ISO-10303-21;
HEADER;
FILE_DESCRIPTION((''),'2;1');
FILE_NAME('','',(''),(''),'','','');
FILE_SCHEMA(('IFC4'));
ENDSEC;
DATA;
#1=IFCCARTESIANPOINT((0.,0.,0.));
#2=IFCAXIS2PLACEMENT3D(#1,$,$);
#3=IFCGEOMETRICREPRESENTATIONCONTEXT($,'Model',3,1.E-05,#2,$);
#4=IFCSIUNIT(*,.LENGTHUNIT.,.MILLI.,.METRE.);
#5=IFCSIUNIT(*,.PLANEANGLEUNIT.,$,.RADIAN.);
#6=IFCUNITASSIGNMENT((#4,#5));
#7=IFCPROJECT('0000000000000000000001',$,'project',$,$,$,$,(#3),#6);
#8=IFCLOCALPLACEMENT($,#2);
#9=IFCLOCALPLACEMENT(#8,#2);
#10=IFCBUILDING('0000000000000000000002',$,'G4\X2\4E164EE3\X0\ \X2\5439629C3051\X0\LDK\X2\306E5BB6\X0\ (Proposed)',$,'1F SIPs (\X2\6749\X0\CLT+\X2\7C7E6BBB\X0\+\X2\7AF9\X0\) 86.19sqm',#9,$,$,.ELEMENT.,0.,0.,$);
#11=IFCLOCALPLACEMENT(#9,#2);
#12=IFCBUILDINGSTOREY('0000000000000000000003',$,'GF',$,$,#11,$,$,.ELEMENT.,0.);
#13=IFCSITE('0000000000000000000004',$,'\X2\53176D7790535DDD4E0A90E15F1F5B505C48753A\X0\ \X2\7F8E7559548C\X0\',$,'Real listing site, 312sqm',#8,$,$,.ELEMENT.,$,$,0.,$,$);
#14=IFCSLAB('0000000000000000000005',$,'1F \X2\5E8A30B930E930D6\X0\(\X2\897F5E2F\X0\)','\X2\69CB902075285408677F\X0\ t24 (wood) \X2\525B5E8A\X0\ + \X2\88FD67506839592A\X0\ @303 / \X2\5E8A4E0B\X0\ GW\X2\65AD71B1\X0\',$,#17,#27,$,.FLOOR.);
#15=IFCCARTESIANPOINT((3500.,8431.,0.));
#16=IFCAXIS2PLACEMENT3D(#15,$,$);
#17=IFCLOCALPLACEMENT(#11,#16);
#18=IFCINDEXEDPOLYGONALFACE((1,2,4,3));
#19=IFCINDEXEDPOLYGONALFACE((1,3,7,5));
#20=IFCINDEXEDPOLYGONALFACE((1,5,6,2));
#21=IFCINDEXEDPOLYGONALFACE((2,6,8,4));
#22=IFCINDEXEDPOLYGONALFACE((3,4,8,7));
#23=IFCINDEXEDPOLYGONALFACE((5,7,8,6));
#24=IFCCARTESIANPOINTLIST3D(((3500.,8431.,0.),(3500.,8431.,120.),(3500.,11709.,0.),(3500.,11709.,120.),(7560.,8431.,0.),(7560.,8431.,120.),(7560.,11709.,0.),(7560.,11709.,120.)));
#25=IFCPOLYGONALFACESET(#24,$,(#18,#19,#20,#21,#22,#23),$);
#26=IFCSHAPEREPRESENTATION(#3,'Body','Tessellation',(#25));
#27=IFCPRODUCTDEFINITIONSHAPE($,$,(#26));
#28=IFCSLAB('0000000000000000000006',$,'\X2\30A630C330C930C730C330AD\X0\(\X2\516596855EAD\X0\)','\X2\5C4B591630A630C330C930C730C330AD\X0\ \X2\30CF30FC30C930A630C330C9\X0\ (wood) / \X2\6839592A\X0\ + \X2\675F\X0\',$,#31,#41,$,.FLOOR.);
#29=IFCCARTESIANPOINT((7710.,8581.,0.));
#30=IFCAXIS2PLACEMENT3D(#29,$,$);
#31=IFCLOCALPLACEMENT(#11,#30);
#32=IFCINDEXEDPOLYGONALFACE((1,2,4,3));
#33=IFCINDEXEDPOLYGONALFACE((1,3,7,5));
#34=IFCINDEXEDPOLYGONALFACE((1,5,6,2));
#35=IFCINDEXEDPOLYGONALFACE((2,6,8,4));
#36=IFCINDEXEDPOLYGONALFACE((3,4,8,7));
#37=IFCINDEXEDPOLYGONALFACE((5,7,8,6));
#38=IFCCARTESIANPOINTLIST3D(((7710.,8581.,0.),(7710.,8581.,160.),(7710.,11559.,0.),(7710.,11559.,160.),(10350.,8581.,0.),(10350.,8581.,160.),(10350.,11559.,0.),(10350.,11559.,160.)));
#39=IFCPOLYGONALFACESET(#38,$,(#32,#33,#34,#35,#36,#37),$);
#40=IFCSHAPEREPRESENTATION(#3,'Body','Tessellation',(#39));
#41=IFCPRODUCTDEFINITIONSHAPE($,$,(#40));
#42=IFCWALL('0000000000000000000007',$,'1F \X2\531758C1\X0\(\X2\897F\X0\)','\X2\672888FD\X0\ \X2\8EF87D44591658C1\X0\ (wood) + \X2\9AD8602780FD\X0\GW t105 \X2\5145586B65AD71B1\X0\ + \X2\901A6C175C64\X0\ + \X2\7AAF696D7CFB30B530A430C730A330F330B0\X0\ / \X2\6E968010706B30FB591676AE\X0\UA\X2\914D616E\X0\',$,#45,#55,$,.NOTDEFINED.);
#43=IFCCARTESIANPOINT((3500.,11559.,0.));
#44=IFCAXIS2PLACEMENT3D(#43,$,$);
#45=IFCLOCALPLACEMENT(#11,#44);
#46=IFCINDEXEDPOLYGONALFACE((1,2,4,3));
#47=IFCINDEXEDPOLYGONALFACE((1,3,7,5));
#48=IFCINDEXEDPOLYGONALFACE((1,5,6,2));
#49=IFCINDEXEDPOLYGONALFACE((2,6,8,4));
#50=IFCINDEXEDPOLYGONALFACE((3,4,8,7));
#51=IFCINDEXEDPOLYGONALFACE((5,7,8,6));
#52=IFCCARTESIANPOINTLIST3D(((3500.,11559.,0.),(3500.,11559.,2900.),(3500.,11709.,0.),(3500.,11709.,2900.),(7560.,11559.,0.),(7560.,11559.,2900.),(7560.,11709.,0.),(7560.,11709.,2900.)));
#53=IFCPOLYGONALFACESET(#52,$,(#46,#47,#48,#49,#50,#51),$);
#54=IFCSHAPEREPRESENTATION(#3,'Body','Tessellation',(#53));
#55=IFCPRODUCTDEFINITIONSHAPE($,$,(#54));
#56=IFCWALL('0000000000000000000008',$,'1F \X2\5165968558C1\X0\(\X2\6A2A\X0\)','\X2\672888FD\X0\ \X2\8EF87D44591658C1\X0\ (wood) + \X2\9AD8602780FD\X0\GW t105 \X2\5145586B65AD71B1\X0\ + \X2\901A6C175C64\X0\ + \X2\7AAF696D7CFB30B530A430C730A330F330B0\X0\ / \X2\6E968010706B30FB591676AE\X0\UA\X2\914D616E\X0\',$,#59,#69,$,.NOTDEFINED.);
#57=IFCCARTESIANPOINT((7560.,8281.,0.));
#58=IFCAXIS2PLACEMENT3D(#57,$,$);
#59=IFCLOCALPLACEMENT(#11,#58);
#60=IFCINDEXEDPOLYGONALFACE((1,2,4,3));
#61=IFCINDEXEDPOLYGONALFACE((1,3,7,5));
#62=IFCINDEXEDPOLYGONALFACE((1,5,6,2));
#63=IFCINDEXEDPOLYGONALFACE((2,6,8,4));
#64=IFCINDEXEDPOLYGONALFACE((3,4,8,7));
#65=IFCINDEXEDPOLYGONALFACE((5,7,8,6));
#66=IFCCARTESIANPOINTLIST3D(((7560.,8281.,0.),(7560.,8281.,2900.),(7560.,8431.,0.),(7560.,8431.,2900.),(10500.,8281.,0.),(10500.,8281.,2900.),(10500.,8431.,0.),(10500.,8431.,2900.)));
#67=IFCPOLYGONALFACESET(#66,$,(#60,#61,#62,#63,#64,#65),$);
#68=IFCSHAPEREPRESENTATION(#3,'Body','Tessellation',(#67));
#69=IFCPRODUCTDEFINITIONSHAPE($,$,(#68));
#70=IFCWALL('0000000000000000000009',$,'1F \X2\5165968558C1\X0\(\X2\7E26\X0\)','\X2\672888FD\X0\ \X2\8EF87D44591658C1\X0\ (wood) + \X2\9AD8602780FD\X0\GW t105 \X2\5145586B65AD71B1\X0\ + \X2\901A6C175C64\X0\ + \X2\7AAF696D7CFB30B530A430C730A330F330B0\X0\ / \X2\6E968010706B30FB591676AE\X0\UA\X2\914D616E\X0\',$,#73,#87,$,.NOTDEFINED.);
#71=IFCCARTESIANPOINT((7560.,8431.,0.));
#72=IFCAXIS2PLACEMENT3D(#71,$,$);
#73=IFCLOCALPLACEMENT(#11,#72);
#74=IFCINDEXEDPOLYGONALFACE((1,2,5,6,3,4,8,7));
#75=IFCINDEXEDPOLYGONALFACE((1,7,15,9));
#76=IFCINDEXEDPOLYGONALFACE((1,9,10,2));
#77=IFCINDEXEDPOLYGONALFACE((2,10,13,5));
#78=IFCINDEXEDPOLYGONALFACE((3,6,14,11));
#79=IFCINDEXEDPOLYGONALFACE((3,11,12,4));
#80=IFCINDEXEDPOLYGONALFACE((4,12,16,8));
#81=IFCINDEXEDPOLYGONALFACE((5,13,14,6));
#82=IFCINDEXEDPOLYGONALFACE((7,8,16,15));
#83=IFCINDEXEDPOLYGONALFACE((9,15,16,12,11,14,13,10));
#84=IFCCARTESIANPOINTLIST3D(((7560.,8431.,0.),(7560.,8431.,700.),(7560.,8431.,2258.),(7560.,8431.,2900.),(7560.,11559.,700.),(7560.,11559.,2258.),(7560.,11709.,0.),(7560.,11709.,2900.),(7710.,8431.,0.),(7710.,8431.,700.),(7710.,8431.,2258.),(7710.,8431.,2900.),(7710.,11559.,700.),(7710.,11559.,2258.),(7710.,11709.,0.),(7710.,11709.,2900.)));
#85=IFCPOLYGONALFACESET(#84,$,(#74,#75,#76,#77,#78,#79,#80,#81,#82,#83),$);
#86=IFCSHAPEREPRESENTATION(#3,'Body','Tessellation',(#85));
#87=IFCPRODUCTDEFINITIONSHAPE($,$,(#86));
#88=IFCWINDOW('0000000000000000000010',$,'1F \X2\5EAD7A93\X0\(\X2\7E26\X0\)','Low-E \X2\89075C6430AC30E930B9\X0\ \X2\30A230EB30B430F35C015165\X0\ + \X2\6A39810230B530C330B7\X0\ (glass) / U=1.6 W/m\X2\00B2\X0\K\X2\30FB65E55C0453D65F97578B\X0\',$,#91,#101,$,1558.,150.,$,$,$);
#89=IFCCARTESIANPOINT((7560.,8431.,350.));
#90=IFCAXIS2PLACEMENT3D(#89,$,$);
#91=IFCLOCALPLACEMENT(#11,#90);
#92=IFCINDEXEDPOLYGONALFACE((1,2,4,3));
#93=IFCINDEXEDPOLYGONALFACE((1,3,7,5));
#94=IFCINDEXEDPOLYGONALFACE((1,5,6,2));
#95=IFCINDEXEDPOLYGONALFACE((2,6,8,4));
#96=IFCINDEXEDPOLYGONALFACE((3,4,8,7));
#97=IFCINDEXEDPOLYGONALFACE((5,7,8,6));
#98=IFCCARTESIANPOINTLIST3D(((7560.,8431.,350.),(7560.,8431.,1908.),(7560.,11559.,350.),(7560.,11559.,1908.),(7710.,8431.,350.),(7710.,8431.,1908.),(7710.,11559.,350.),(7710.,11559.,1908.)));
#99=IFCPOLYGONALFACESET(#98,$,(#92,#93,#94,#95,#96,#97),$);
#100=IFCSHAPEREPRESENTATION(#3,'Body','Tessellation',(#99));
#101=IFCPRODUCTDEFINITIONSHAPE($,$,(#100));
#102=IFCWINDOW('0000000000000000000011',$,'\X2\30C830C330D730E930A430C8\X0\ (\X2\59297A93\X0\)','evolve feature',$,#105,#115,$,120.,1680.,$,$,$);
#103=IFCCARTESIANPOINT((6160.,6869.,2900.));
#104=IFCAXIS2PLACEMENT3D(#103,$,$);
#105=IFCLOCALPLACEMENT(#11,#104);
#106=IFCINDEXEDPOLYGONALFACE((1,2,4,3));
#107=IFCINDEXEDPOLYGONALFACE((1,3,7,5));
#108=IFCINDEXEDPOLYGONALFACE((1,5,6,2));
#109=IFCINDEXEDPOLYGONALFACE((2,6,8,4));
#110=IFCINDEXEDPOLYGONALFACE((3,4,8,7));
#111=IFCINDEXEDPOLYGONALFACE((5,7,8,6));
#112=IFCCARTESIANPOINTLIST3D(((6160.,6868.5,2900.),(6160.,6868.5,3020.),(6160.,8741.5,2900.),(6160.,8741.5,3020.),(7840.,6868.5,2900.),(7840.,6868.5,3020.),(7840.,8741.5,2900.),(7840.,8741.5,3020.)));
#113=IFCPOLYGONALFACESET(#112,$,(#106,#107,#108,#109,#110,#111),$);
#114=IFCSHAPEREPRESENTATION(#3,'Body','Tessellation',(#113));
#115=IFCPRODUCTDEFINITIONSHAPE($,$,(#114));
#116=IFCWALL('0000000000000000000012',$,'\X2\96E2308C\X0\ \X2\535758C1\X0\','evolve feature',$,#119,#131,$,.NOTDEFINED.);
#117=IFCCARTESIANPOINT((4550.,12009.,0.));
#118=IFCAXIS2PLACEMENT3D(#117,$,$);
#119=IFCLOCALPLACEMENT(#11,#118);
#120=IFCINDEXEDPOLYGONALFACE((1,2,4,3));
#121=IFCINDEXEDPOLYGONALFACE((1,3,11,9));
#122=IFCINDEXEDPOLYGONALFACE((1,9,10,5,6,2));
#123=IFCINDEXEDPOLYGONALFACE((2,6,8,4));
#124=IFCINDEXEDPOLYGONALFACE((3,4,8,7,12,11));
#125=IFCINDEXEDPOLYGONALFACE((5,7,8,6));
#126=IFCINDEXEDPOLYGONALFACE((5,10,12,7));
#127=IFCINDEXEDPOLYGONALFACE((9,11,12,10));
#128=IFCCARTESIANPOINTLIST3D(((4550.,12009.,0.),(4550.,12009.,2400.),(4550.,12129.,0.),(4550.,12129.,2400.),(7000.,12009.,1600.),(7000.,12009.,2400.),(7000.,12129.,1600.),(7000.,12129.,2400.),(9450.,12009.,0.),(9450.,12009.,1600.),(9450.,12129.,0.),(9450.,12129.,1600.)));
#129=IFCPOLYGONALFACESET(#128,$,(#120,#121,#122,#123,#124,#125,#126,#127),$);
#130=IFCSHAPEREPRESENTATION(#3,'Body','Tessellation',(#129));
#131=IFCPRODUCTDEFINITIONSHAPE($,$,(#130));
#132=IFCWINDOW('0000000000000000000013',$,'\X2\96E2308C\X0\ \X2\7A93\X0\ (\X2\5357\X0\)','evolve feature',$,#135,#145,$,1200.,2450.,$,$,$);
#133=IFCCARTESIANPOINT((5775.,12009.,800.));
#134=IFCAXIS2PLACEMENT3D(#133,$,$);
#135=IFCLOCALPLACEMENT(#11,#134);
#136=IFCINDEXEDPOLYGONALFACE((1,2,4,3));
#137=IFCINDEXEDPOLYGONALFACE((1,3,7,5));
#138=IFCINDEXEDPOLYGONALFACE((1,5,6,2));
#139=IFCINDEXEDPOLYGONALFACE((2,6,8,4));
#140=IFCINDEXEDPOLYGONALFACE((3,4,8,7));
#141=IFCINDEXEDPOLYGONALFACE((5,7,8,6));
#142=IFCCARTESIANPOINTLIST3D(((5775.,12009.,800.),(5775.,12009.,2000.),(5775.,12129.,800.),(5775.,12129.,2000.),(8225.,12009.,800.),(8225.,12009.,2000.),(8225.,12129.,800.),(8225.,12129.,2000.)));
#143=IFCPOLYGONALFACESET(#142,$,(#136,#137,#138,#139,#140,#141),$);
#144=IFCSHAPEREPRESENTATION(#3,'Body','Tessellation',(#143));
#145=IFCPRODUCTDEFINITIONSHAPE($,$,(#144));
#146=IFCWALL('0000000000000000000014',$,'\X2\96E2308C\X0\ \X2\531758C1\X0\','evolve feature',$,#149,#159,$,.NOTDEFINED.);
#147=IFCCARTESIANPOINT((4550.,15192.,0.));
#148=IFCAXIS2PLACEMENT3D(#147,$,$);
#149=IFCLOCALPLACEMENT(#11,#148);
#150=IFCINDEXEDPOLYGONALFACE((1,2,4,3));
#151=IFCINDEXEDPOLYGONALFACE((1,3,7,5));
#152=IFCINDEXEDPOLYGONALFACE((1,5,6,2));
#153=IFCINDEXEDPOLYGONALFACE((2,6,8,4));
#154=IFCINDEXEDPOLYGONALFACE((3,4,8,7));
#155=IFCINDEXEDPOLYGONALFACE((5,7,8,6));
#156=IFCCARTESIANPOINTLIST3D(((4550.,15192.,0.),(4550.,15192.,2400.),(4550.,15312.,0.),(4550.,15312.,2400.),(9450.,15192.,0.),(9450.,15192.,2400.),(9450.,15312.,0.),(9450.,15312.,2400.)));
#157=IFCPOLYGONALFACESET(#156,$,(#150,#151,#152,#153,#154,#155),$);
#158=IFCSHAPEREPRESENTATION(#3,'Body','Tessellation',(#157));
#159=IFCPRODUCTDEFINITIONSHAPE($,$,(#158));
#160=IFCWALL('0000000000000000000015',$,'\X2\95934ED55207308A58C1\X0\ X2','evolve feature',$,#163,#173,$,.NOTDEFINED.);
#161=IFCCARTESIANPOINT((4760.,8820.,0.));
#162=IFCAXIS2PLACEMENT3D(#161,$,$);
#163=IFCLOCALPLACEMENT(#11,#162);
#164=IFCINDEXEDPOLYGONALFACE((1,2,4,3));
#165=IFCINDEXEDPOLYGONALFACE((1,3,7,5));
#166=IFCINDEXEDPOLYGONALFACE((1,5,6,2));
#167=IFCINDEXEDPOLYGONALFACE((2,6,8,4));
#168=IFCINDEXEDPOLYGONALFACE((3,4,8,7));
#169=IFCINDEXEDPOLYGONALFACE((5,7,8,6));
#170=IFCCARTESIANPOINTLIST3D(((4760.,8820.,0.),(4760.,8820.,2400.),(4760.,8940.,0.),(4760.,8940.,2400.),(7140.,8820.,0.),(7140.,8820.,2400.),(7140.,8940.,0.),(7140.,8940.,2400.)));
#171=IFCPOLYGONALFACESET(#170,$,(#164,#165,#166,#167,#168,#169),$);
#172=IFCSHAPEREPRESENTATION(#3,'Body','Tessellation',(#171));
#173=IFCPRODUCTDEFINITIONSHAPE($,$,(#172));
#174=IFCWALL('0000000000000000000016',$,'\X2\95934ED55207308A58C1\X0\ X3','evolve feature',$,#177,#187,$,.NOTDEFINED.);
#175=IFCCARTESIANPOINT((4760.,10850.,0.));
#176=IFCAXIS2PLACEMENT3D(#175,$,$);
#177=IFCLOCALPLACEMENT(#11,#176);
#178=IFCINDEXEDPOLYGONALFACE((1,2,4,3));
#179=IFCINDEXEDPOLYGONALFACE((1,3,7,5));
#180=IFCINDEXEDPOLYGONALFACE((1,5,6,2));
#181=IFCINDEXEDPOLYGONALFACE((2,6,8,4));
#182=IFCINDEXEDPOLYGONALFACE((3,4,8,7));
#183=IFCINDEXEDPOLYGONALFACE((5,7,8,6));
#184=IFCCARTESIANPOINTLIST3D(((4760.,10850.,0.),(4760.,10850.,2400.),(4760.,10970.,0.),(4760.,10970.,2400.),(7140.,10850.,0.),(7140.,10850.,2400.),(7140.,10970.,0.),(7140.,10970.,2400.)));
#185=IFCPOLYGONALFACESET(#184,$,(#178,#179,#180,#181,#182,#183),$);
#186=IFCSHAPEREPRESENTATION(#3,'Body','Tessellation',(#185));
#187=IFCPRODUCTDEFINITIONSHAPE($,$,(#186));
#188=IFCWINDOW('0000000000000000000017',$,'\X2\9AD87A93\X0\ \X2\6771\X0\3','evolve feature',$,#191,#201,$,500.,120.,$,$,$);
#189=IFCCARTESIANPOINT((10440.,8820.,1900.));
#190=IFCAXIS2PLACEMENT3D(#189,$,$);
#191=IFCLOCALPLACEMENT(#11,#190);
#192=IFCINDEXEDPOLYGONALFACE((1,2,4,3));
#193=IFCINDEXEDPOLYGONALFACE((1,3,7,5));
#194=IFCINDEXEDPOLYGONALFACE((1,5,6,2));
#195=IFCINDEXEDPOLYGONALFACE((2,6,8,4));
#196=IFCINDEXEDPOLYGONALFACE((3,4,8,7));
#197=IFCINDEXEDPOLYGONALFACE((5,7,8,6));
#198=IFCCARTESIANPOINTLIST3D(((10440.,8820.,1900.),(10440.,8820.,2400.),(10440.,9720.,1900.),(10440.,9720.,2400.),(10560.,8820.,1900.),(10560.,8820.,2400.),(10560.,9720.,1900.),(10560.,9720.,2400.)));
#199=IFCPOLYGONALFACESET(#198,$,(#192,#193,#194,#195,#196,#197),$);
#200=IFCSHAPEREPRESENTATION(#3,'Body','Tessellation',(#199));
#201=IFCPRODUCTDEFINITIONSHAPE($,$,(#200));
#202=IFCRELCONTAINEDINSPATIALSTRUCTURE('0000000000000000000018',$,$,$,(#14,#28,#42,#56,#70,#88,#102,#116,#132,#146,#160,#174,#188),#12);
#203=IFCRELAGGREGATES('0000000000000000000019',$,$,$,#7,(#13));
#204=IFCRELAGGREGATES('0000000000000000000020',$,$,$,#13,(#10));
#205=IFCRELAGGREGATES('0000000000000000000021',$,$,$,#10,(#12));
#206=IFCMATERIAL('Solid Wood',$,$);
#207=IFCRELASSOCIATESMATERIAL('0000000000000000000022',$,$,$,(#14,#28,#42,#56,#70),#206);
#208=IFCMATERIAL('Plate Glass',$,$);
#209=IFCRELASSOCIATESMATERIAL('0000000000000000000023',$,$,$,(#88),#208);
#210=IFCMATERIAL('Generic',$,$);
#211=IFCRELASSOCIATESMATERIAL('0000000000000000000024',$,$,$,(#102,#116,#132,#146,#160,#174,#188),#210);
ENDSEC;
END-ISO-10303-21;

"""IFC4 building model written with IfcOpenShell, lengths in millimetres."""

from ifc_helpers import new_model, si_unit, frame, frame_2d, origin, place, context, project, spatial, rectangle, extrude, material, element, fill, save


model = new_model("IFC4")

# Units and contexts
model_context = context("Model", 3, precision=1e-05, world=origin())
ifc_project = project(units=[si_unit("LENGTHUNIT", "METRE", prefix="MILLI"), si_unit("PLANEANGLEUNIT", "RADIAN")], contexts=[model_context])

# Site, building, storey
site_placement = place(None, origin())
site = spatial("IfcSite", under=ifc_project, at=site_placement, Name="北海道川上郡弟子屈町 美留和", ObjectType="Real listing site, 312sqm", CompositionType="ELEMENT", RefElevation=0.0)
building_placement = place(site_placement, origin())
building = spatial("IfcBuilding", under=site, at=building_placement, Name="G4世代 吹抜けLDKの家 (Proposed)", ObjectType="1F SIPs (杉CLT+籾殻+竹) 86.19sqm", CompositionType="ELEMENT", ElevationOfRefHeight=0.0, ElevationOfTerrain=0.0)
storey_placement = place(building_placement, origin())
storey = spatial("IfcBuildingStorey", under=building, at=storey_placement, Name="GF", CompositionType="ELEMENT", Elevation=0.0)

# Slabs
ifc_material_1 = material(Name="Solid Wood")
slab_1_placement = place(storey_placement, frame((3500.0, 8431.0, 0.0)))
element("IfcSlab", 1, at=slab_1_placement, inside=storey, material=ifc_material_1, Name="1F 床スラブ(西帯)", Description="構造用合板 t24 (wood) 剛床 + 製材根太 @303 / 床下 GW断熱", PredefinedType="FLOOR", context=model_context, shape_type="SweptSolid", body=[
    extrude(rectangle(XDim=4060.0, YDim=3278.0, at=frame_2d((2030.0, 1639.0))), frame((3500.0, 8431.0, 0.0)), (0.0, 0.0, 1.0), 120.0),
])
slab_2_placement = place(storey_placement, frame((7710.0, 8581.0, 0.0)))
element("IfcSlab", 2, at=slab_2_placement, inside=storey, material=ifc_material_1, Name="ウッドデッキ(入隅庭)", Description="屋外ウッドデッキ ハードウッド (wood) / 根太 + 束", PredefinedType="FLOOR", context=model_context, shape_type="SweptSolid", body=[
    extrude(rectangle(XDim=2640.0, YDim=2978.0, at=frame_2d((1320.0, 1489.0))), frame((7710.0, 8581.0, 0.0)), (0.0, 0.0, 1.0), 160.0),
])
ifc_material_2 = material(Name="Generic")

# Walls
wall_1_placement = place(storey_placement, frame((3500.0, 11559.0, 0.0)))
element("IfcWall", 3, at=wall_1_placement, inside=storey, material=ifc_material_1, Name="1F 北壁(西)", Description="木製 軸組外壁 (wood) + 高性能GW t105 充填断熱 + 通気層 + 窯業系サイディング / 準耐火・外皮UA配慮", PredefinedType="NOTDEFINED", context=model_context, shape_type="SweptSolid", body=[
    extrude(rectangle(XDim=4060.0, YDim=150.0, at=frame_2d((2030.0, 75.0))), frame((3500.0, 11559.0, 0.0)), (0.0, 0.0, 1.0), 2900.0),
])
wall_2_placement = place(storey_placement, frame((7560.0, 8281.0, 0.0)))
element("IfcWall", 4, at=wall_2_placement, inside=storey, material=ifc_material_1, Name="1F 入隅壁(横)", Description="木製 軸組外壁 (wood) + 高性能GW t105 充填断熱 + 通気層 + 窯業系サイディング / 準耐火・外皮UA配慮", PredefinedType="NOTDEFINED", context=model_context, shape_type="SweptSolid", body=[
    extrude(rectangle(XDim=2940.0, YDim=150.0, at=frame_2d((1470.0, 75.0))), frame((7560.0, 8281.0, 0.0)), (0.0, 0.0, 1.0), 2900.0),
])

# Wall, opening, window
wall_3_placement = place(storey_placement, frame((7560.0, 8431.0, 0.0)))
wall_3 = element("IfcWall", 5, at=wall_3_placement, inside=storey, material=ifc_material_1, Name="1F 入隅壁(縦)", Description="木製 軸組外壁 (wood) + 高性能GW t105 充填断熱 + 通気層 + 窯業系サイディング / 準耐火・外皮UA配慮", PredefinedType="NOTDEFINED", context=model_context, shape_type="SweptSolid", body=[
    extrude(rectangle(XDim=150.0, YDim=3278.0, at=frame_2d((75.0, 1639.0))), frame((7560.0, 8431.0, 0.0)), (0.0, 0.0, 1.0), 2900.0),
])
opening_1_placement = place(storey_placement, frame((7560.0, 8431.0, 350.0)))
opening_1 = element("IfcOpeningElement", 6, at=opening_1_placement, cuts=wall_3, PredefinedType="NOTDEFINED", context=model_context, shape_type="SweptSolid", body=[
    extrude(rectangle(XDim=150.0, YDim=3128.0, at=frame_2d((75.0, 1564.0))), frame((7560.0, 8431.0, 350.0)), (0.0, 0.0, 1.0), 1558.0),
])
ifc_material_3 = material(Name="Plate Glass")
window_1_placement = place(storey_placement, frame((7560.0, 8431.0, 350.0)))
window_1 = element("IfcWindow", 7, at=window_1_placement, inside=storey, material=ifc_material_3, Name="1F 庭窓(縦)", Description="Low-E 複層ガラス アルゴン封入 + 樹脂サッシ (glass) / U=1.6 W/m²K・日射取得型", OverallHeight=1558.0, OverallWidth=150.0, context=model_context, shape_type="SweptSolid", body=[
    extrude(rectangle(XDim=150.0, YDim=3128.0, at=frame_2d((75.0, 1564.0))), frame((7560.0, 8431.0, 350.0)), (0.0, 0.0, 1.0), 1558.0),
])
fill(opening_1, window_1)

# Window
window_2_placement = place(storey_placement, frame((6160.0, 6869.0, 2900.0)))
element("IfcWindow", 8, at=window_2_placement, inside=storey, material=ifc_material_2, Name="トップライト (天窓)", Description="evolve feature", OverallHeight=120.0, OverallWidth=1680.0, context=model_context, shape_type="SweptSolid", body=[
    extrude(rectangle(XDim=1680.0, YDim=1873.0, at=frame_2d((840.0, 936.0))), frame((6160.0, 6869.0, 2900.0)), (0.0, 0.0, 1.0), 120.0),
])

# Wall, opening, window
wall_4_placement = place(storey_placement, frame((4550.0, 12009.0, 0.0)))
wall_4 = element("IfcWall", 9, at=wall_4_placement, inside=storey, material=ifc_material_2, Name="離れ 南壁", Description="evolve feature", PredefinedType="NOTDEFINED", context=model_context, shape_type="SweptSolid", body=[
    extrude(rectangle(XDim=4900.0, YDim=120.0, at=frame_2d((2450.0, 60.0))), frame((4550.0, 12009.0, 0.0)), (0.0, 0.0, 1.0), 2400.0),
])
opening_2_placement = place(storey_placement, frame((5775.0, 12009.0, 800.0)))
opening_2 = element("IfcOpeningElement", 10, at=opening_2_placement, cuts=wall_4, PredefinedType="NOTDEFINED", context=model_context, shape_type="SweptSolid", body=[
    extrude(rectangle(XDim=2450.0, YDim=120.0, at=frame_2d((1225.0, 60.0))), frame((5775.0, 12009.0, 800.0)), (0.0, 0.0, 1.0), 1200.0),
])
window_3_placement = place(storey_placement, frame((5775.0, 12009.0, 800.0)))
window_3 = element("IfcWindow", 11, at=window_3_placement, inside=storey, material=ifc_material_2, Name="離れ 窓 (南)", Description="evolve feature", OverallHeight=1200.0, OverallWidth=2450.0, context=model_context, shape_type="SweptSolid", body=[
    extrude(rectangle(XDim=2450.0, YDim=120.0, at=frame_2d((1225.0, 60.0))), frame((5775.0, 12009.0, 800.0)), (0.0, 0.0, 1.0), 1200.0),
])
fill(opening_2, window_3)

# Walls
wall_5_placement = place(storey_placement, frame((4550.0, 15192.0, 0.0)))
element("IfcWall", 12, at=wall_5_placement, inside=storey, material=ifc_material_2, Name="離れ 北壁", Description="evolve feature", PredefinedType="NOTDEFINED", context=model_context, shape_type="SweptSolid", body=[
    extrude(rectangle(XDim=4900.0, YDim=120.0, at=frame_2d((2450.0, 60.0))), frame((4550.0, 15192.0, 0.0)), (0.0, 0.0, 1.0), 2400.0),
])
wall_6_placement = place(storey_placement, frame((4760.0, 8820.0, 0.0)))
element("IfcWall", 13, at=wall_6_placement, inside=storey, material=ifc_material_2, Name="間仕切り壁 X2", Description="evolve feature", PredefinedType="NOTDEFINED", context=model_context, shape_type="SweptSolid", body=[
    extrude(rectangle(XDim=2380.0, YDim=120.0, at=frame_2d((1190.0, 60.0))), frame((4760.0, 8820.0, 0.0)), (0.0, 0.0, 1.0), 2400.0),
])
wall_7_placement = place(storey_placement, frame((4760.0, 10850.0, 0.0)))
element("IfcWall", 14, at=wall_7_placement, inside=storey, material=ifc_material_2, Name="間仕切り壁 X3", Description="evolve feature", PredefinedType="NOTDEFINED", context=model_context, shape_type="SweptSolid", body=[
    extrude(rectangle(XDim=2380.0, YDim=120.0, at=frame_2d((1190.0, 60.0))), frame((4760.0, 10850.0, 0.0)), (0.0, 0.0, 1.0), 2400.0),
])

# Window
window_4_placement = place(storey_placement, frame((10440.0, 8820.0, 1900.0)))
element("IfcWindow", 15, at=window_4_placement, inside=storey, material=ifc_material_2, Name="高窓 東3", Description="evolve feature", OverallHeight=500.0, OverallWidth=120.0, context=model_context, shape_type="SweptSolid", body=[
    extrude(rectangle(XDim=120.0, YDim=900.0, at=frame_2d((60.0, 450.0))), frame((10440.0, 8820.0, 1900.0)), (0.0, 0.0, 1.0), 500.0),
])

save(model, "model.ifc")
